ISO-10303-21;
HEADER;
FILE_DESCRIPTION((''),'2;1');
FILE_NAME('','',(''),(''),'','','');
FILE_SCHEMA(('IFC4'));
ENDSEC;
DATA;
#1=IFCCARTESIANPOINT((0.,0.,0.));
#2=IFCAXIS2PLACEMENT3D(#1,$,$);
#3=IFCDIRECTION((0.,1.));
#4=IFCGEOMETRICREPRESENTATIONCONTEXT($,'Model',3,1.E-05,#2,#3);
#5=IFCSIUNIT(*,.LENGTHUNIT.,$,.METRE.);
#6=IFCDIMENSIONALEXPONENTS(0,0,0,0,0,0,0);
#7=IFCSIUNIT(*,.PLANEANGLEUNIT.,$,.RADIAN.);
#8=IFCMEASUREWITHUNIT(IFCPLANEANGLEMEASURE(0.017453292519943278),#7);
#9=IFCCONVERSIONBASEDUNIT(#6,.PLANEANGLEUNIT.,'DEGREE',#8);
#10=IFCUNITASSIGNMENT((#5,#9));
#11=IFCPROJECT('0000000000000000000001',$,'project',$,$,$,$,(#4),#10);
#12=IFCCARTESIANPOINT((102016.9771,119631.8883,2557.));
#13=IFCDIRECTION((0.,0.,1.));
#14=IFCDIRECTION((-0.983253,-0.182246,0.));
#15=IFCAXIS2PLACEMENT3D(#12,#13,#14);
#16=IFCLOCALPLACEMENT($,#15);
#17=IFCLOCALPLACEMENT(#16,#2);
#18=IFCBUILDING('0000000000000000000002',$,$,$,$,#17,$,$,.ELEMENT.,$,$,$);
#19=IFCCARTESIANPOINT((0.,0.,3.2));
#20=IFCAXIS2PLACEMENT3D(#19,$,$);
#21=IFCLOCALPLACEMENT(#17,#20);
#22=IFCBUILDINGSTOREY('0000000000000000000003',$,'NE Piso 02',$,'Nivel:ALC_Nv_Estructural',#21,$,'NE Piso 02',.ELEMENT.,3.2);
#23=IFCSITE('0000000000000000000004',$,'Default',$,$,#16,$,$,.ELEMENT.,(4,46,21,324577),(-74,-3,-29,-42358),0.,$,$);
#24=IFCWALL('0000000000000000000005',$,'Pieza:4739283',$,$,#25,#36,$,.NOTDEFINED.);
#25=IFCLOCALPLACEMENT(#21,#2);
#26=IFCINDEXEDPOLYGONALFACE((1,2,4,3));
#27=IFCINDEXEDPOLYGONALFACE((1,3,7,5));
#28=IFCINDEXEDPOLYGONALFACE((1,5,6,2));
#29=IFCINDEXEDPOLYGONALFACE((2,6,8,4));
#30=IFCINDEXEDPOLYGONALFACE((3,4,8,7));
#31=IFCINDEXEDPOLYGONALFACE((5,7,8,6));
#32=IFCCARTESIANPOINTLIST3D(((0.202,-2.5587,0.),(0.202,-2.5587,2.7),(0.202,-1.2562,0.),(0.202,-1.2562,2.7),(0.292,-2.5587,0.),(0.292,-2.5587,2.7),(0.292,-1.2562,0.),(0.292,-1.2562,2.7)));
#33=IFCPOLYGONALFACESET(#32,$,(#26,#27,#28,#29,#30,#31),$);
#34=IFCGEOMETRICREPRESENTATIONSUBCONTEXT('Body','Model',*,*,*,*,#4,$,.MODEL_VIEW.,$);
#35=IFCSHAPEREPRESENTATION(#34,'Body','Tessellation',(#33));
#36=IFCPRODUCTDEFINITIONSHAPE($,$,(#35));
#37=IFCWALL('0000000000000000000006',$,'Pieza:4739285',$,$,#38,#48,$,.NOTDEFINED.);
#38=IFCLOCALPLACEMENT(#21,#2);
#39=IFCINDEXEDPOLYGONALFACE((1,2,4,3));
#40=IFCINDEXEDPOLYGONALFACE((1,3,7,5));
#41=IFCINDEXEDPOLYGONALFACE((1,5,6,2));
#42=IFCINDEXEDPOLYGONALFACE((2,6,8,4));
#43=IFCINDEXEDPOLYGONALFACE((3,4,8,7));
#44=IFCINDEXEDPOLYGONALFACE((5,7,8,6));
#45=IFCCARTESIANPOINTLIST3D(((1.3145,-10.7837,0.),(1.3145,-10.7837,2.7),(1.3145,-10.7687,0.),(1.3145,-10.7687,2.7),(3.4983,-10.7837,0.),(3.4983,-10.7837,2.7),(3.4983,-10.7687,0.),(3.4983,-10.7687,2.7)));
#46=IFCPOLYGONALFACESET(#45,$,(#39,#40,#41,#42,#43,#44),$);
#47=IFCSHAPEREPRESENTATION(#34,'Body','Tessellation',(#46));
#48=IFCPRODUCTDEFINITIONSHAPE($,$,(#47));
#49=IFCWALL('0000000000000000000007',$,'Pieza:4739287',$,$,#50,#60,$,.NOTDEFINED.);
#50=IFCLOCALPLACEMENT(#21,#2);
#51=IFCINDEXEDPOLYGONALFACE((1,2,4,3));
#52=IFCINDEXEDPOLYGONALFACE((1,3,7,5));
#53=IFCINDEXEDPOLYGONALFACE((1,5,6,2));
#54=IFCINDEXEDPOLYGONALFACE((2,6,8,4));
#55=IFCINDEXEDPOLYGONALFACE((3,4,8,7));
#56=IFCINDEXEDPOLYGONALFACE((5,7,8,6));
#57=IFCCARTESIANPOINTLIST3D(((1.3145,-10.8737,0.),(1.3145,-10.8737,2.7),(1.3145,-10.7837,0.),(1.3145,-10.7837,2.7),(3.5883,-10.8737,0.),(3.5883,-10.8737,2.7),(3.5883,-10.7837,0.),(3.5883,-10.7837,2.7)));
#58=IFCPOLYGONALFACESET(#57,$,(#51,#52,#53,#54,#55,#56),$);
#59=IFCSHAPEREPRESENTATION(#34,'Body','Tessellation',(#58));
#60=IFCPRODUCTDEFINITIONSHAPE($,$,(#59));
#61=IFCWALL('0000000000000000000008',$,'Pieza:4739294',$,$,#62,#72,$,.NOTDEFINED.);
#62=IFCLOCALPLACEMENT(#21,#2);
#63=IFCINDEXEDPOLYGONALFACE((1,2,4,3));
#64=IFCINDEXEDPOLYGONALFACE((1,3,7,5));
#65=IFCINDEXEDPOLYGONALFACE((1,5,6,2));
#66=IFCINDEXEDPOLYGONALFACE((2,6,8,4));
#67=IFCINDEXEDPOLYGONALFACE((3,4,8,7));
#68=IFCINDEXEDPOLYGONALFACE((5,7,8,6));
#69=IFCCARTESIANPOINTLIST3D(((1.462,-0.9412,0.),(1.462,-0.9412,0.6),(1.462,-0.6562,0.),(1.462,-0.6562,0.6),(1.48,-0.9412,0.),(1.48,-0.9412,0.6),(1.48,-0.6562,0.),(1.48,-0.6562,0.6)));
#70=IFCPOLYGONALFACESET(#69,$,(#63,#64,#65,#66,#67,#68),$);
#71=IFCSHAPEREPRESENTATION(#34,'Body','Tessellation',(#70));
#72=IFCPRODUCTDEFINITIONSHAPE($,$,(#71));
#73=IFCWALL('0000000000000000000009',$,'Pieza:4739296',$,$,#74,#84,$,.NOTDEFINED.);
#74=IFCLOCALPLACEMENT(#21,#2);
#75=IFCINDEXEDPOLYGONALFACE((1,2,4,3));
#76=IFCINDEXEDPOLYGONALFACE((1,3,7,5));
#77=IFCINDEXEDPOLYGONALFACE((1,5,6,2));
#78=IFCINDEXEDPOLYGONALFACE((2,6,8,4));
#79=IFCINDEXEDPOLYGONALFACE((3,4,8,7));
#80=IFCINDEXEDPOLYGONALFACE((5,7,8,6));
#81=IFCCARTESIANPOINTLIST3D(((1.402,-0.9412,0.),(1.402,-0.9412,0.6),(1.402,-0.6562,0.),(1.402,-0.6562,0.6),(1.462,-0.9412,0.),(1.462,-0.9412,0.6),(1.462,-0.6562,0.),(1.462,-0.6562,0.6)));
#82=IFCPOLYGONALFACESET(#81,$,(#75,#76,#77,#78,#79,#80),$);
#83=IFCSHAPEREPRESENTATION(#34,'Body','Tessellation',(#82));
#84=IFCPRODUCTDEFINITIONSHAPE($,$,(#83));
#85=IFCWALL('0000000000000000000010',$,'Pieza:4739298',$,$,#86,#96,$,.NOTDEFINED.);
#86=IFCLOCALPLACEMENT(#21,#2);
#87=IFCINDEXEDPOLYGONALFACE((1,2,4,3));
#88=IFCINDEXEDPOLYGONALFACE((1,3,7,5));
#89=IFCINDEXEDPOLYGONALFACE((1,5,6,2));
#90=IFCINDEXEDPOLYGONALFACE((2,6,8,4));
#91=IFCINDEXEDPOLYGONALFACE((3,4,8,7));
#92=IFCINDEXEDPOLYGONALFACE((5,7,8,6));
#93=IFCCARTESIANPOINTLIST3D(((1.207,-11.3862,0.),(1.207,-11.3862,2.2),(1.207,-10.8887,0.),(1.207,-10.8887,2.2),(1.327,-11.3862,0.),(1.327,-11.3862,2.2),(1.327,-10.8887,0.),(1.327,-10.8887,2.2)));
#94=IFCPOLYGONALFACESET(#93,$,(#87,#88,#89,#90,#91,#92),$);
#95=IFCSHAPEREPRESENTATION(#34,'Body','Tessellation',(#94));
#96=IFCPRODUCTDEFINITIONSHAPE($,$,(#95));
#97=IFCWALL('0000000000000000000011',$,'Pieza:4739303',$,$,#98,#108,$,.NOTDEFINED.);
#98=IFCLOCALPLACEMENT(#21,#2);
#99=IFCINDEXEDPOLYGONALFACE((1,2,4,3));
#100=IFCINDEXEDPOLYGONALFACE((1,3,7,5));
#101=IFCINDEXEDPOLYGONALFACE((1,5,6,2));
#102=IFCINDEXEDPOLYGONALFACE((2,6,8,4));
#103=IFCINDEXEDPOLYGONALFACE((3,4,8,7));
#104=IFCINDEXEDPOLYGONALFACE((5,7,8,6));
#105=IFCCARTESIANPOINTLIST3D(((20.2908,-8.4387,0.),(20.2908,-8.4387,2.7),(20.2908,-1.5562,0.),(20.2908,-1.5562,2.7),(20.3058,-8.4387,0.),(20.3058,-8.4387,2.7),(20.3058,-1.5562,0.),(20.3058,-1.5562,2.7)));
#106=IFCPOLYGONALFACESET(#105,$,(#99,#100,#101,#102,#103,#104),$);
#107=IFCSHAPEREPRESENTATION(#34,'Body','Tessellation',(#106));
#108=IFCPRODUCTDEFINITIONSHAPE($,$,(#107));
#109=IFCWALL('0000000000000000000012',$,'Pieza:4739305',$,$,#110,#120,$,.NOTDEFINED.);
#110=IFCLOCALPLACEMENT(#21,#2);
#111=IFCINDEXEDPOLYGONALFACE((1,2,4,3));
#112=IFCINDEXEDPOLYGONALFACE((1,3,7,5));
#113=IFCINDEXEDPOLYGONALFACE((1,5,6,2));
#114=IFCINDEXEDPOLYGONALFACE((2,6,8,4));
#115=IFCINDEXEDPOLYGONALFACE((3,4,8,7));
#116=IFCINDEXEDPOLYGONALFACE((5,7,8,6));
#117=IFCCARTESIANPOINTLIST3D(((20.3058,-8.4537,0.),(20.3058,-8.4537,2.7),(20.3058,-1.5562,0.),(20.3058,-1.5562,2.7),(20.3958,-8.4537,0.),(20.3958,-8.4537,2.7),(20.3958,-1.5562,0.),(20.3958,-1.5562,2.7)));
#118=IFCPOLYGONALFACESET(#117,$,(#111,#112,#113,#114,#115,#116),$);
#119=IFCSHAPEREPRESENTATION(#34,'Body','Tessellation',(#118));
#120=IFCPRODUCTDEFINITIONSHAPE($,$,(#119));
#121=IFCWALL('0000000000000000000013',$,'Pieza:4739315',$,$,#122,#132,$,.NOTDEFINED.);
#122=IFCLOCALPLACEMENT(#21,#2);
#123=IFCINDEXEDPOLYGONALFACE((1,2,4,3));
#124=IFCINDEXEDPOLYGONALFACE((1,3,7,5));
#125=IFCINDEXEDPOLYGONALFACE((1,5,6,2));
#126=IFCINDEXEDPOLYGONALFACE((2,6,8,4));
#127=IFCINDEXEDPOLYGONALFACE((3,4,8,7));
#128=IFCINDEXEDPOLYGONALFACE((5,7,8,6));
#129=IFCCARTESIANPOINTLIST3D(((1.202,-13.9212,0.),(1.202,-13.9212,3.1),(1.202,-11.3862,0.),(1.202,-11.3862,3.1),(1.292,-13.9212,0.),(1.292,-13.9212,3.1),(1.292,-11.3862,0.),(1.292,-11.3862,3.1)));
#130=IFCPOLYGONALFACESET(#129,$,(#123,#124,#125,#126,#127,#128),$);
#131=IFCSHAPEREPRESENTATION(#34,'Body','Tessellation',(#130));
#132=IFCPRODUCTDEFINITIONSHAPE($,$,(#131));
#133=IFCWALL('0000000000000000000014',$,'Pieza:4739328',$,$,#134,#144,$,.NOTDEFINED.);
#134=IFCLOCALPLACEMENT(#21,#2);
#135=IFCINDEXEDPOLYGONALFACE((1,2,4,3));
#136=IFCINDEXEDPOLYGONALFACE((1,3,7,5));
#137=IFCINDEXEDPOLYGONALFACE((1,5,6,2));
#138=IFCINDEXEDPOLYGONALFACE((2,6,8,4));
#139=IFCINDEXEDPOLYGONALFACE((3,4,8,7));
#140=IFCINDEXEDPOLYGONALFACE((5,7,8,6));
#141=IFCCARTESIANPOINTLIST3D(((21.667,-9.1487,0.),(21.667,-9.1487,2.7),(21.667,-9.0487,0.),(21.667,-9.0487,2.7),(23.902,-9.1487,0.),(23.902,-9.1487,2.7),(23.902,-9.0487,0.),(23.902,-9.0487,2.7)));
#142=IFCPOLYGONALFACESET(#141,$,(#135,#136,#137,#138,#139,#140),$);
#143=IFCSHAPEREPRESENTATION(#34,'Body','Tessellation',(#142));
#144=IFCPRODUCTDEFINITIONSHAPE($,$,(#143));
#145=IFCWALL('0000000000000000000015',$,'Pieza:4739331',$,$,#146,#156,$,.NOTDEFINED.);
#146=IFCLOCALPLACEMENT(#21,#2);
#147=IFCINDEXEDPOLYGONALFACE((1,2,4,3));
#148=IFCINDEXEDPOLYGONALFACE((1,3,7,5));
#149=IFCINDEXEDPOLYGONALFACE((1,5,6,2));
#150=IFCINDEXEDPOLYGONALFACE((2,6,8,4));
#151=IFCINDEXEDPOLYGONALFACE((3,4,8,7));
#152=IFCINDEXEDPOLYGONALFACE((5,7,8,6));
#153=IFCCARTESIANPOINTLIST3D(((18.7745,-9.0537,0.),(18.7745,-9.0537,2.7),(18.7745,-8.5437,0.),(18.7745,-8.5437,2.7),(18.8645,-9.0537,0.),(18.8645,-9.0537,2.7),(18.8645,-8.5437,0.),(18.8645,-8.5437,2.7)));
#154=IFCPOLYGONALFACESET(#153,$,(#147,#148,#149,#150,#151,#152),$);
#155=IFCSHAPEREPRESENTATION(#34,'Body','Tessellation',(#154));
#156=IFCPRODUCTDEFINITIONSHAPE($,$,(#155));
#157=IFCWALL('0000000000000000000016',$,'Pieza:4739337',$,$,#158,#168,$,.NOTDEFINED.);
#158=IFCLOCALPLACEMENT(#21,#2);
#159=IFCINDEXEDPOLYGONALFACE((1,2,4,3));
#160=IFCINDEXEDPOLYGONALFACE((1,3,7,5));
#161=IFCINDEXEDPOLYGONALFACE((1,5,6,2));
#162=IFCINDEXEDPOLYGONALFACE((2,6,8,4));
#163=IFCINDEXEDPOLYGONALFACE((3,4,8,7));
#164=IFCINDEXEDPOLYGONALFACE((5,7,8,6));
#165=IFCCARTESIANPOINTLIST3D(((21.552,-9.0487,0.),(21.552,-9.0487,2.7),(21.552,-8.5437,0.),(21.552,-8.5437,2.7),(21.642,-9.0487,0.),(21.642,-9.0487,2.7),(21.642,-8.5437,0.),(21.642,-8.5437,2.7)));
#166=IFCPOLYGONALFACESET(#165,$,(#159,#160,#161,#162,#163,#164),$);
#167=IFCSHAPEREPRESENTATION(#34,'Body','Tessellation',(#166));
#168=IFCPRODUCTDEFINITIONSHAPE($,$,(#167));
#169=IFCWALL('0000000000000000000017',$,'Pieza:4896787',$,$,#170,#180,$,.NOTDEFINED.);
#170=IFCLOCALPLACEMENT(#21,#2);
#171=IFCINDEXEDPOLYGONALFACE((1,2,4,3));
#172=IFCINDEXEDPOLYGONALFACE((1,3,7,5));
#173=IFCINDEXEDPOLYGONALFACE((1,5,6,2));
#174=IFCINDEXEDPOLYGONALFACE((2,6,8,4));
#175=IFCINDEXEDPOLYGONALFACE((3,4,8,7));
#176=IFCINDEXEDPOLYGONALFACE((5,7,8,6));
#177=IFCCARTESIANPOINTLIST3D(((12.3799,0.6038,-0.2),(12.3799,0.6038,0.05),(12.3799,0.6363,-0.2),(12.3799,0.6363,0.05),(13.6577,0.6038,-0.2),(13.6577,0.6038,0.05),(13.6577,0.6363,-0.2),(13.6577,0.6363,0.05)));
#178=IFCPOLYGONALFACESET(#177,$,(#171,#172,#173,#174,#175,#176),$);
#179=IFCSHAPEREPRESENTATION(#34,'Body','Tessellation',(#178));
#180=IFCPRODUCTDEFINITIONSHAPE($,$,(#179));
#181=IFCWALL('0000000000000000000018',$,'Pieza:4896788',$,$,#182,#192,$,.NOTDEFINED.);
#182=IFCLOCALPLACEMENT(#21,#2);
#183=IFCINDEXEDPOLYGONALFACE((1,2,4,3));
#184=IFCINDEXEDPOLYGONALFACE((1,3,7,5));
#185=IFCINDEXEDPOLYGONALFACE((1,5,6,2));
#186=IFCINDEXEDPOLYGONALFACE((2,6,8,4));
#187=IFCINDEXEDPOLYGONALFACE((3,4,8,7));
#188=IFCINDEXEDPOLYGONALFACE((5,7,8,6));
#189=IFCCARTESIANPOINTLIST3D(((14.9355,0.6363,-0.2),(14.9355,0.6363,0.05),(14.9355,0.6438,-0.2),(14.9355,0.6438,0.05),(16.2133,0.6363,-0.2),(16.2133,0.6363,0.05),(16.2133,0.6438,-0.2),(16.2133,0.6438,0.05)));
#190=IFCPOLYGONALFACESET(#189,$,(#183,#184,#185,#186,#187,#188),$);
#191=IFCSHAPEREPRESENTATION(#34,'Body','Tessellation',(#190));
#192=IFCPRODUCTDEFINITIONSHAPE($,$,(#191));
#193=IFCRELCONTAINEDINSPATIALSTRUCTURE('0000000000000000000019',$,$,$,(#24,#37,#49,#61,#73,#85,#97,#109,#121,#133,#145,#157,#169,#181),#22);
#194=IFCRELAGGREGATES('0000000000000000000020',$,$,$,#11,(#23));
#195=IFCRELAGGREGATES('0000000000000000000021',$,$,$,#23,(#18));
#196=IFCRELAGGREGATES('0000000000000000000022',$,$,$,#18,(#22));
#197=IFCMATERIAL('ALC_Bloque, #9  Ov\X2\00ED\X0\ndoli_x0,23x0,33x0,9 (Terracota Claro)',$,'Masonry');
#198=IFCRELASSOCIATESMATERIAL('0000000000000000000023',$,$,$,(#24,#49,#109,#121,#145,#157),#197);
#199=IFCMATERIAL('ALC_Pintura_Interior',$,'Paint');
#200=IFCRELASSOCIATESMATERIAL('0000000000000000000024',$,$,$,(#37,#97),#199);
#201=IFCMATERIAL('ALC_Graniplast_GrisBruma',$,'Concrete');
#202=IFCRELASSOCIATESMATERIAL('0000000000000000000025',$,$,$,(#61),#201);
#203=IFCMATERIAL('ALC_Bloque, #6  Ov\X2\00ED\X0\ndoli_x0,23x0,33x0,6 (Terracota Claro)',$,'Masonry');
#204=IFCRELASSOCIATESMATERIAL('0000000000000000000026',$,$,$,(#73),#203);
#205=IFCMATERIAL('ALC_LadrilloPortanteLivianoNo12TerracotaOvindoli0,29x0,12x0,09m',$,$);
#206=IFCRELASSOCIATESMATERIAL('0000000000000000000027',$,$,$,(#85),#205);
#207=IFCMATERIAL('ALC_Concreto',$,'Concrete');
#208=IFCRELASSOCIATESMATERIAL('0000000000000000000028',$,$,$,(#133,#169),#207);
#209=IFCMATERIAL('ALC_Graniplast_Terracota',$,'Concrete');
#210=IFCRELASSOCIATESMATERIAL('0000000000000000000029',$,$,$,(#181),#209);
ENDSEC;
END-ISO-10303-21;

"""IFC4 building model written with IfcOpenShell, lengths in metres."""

from ifc_helpers import new_model, entity, si_unit, converted_unit, direction, frame, frame_2d, origin, origin_2d_with_axis, place, context, subcontext, project, spatial, rectangle, extrude, material, element, save


model = new_model("IFC4")

# Units and contexts
model_context = context("Model", 3, precision=1e-05, world=origin(), true_north=direction((0.0, 1.0)))
body_context = subcontext(model_context, "Body", "Model", "MODEL_VIEW")
ifc_project = project(units=[si_unit("LENGTHUNIT", "METRE"), converted_unit("PLANEANGLEUNIT", "DEGREE", entity("IfcPlaneAngleMeasure", 0.017453292519943278), si_unit("PLANEANGLEUNIT", "RADIAN"), dimensions=[0, 0, 0, 0, 0, 0, 0])], contexts=[model_context])

# Site, building, storey
site_placement = place(None, frame((102016.9771, 119631.8883, 2557.0), z_axis=(0.0, 0.0, 1.0), x_axis=(-0.983253, -0.182246, 0.0)))
site = spatial("IfcSite", under=ifc_project, at=site_placement, Name="Default", CompositionType="ELEMENT", RefLatitude=(4, 46, 21, 324577), RefLongitude=(-74, -3, -29, -42358), RefElevation=0.0)
building_placement = place(site_placement, origin())
building = spatial("IfcBuilding", under=site, at=building_placement, CompositionType="ELEMENT")
storey_placement = place(building_placement, frame((0.0, 0.0, 3.2)))
storey = spatial("IfcBuildingStorey", under=building, at=storey_placement, Name="NE Piso 02", ObjectType="Nivel:ALC_Nv_Estructural", LongName="NE Piso 02", CompositionType="ELEMENT", Elevation=3.2)

# Walls
ifc_material_1 = material(Name="ALC_Bloque, #9  Ovíndoli_x0,23x0,33x0,9 (Terracota Claro)", Category="Masonry")
wall_1_placement = place(storey_placement, origin())
element("IfcWall", 1, at=wall_1_placement, inside=storey, material=ifc_material_1, Name="Pieza:4739283", PredefinedType="NOTDEFINED", context=body_context, shape_type="SweptSolid", body=[
    extrude(rectangle(XDim=1.3025, YDim=0.09, at=frame_2d((0.0, 0.0), x_axis=(1.0, 0.0))), frame((0.247, -1.9074, 0.0), z_axis=(0.0, 0.0, 1.0), x_axis=(0.0, -1.0, 0.0)), (0.0, 0.0, 1.0), 2.7),
])
ifc_material_2 = material(Name="ALC_Pintura_Interior", Category="Paint")
wall_2_placement = place(storey_placement, origin())
element("IfcWall", 2, at=wall_2_placement, inside=storey, material=ifc_material_2, Name="Pieza:4739285", PredefinedType="NOTDEFINED", context=body_context, shape_type="SweptSolid", body=[
    extrude(rectangle(XDim=0.015, YDim=2.1838, at=frame_2d((0.0, 0.0), x_axis=(1.0, 0.0))), frame((2.4064, -10.7762, 0.0), z_axis=(0.0, 0.0, 1.0), x_axis=(0.0, -1.0, 0.0)), (0.0, 0.0, 1.0), 2.7),
])
wall_3_placement = place(storey_placement, origin())
element("IfcWall", 3, at=wall_3_placement, inside=storey, material=ifc_material_1, Name="Pieza:4739287", PredefinedType="NOTDEFINED", context=body_context, shape_type="SweptSolid", body=[
    extrude(rectangle(XDim=0.09, YDim=2.2738, at=frame_2d((0.0, 0.0), x_axis=(1.0, 0.0))), frame((2.4514, -10.8287, 0.0), z_axis=(0.0, 0.0, 1.0), x_axis=(0.0, -1.0, 0.0)), (0.0, 0.0, 1.0), 2.7),
])
ifc_material_3 = material(Name="ALC_Graniplast_GrisBruma", Category="Concrete")
wall_4_placement = place(storey_placement, origin())
element("IfcWall", 4, at=wall_4_placement, inside=storey, material=ifc_material_3, Name="Pieza:4739294", PredefinedType="NOTDEFINED", context=body_context, shape_type="SweptSolid", body=[
    extrude(rectangle(XDim=0.285, YDim=0.018, at=frame_2d((0.0, 0.0), x_axis=(1.0, 0.0))), frame((1.471, -0.7987, 0.0), z_axis=(0.0, 0.0, 1.0), x_axis=(0.0, -1.0, 0.0)), (0.0, 0.0, 1.0), 0.6),
])
ifc_material_4 = material(Name="ALC_Bloque, #6  Ovíndoli_x0,23x0,33x0,6 (Terracota Claro)", Category="Masonry")
wall_5_placement = place(storey_placement, origin())
element("IfcWall", 5, at=wall_5_placement, inside=storey, material=ifc_material_4, Name="Pieza:4739296", PredefinedType="NOTDEFINED", context=body_context, shape_type="SweptSolid", body=[
    extrude(rectangle(XDim=0.285, YDim=0.06, at=frame_2d((0.0, 0.0), x_axis=(1.0, 0.0))), frame((1.432, -0.7987, 0.0), z_axis=(0.0, 0.0, 1.0), x_axis=(0.0, -1.0, 0.0)), (0.0, 0.0, 1.0), 0.6),
])
ifc_material_5 = material(Name="ALC_LadrilloPortanteLivianoNo12TerracotaOvindoli0,29x0,12x0,09m")
wall_6_placement = place(storey_placement, origin())
element("IfcWall", 6, at=wall_6_placement, inside=storey, material=ifc_material_5, Name="Pieza:4739298", PredefinedType="NOTDEFINED", context=body_context, shape_type="SweptSolid", body=[
    extrude(rectangle(XDim=0.4975, YDim=0.12, at=frame_2d((0.0, 0.0), x_axis=(1.0, 0.0))), frame((1.267, -11.1374, 0.0), z_axis=(0.0, 0.0, 1.0), x_axis=(0.0, -1.0, 0.0)), (0.0, 0.0, 1.0), 2.2),
])
wall_7_placement = place(storey_placement, origin())
element("IfcWall", 7, at=wall_7_placement, inside=storey, material=ifc_material_2, Name="Pieza:4739303", PredefinedType="NOTDEFINED", context=body_context, shape_type="SweptSolid", body=[
    extrude(rectangle(XDim=6.8825, YDim=0.015, at=frame_2d((0.0, 0.0), x_axis=(1.0, 0.0))), frame((20.2983, -4.9974, 0.0), z_axis=(0.0, 0.0, 1.0), x_axis=(0.0, -1.0, 0.0)), (0.0, 0.0, 1.0), 2.7),
])
wall_8_placement = place(storey_placement, origin())
element("IfcWall", 8, at=wall_8_placement, inside=storey, material=ifc_material_1, Name="Pieza:4739305", PredefinedType="NOTDEFINED", context=body_context, shape_type="SweptSolid", body=[
    extrude(rectangle(XDim=6.8975, YDim=0.09, at=frame_2d((0.0, 0.0), x_axis=(1.0, 0.0))), frame((20.3508, -5.0049, 0.0), z_axis=(0.0, 0.0, 1.0), x_axis=(0.0, -1.0, 0.0)), (0.0, 0.0, 1.0), 2.7),
])
wall_9_placement = place(storey_placement, origin())
element("IfcWall", 9, at=wall_9_placement, inside=storey, material=ifc_material_1, Name="Pieza:4739315", PredefinedType="NOTDEFINED", context=body_context, shape_type="SweptSolid", body=[
    extrude(rectangle(XDim=2.535, YDim=0.09, at=frame_2d((0.0, 0.0), x_axis=(1.0, 0.0))), frame((1.247, -12.6537, 0.0), z_axis=(0.0, 0.0, 1.0), x_axis=(0.0, -1.0, 0.0)), (0.0, 0.0, 1.0), 3.1),
])
ifc_material_6 = material(Name="ALC_Concreto", Category="Concrete")
wall_10_placement = place(storey_placement, origin())
element("IfcWall", 10, at=wall_10_placement, inside=storey, material=ifc_material_6, Name="Pieza:4739328", PredefinedType="NOTDEFINED", context=body_context, shape_type="SweptSolid", body=[
    extrude(rectangle(XDim=0.1, YDim=2.235, at=frame_2d((0.0, 0.0), x_axis=(1.0, 0.0))), frame((22.7845, -9.0987, 0.0), z_axis=(0.0, 0.0, 1.0), x_axis=(0.0, -1.0, 0.0)), (0.0, 0.0, 1.0), 2.7),
])
wall_11_placement = place(storey_placement, origin())
element("IfcWall", 11, at=wall_11_placement, inside=storey, material=ifc_material_1, Name="Pieza:4739331", PredefinedType="NOTDEFINED", context=body_context, shape_type="SweptSolid", body=[
    extrude(rectangle(XDim=0.51, YDim=0.09, at=origin_2d_with_axis()), frame((18.8195, -8.7987, 0.0), z_axis=(0.0, 0.0, 1.0), x_axis=(0.0, -1.0, 0.0)), (0.0, 0.0, 1.0), 2.7),
])
wall_12_placement = place(storey_placement, origin())
element("IfcWall", 12, at=wall_12_placement, inside=storey, material=ifc_material_1, Name="Pieza:4739337", PredefinedType="NOTDEFINED", context=body_context, shape_type="SweptSolid", body=[
    extrude(rectangle(XDim=0.505, YDim=0.09, at=origin_2d_with_axis()), frame((21.597, -8.7962, 0.0), z_axis=(0.0, 0.0, 1.0), x_axis=(0.0, -1.0, 0.0)), (0.0, 0.0, 1.0), 2.7),
])
wall_13_placement = place(storey_placement, frame((0.0, 0.0, -0.2)))
element("IfcWall", 13, at=wall_13_placement, inside=storey, material=ifc_material_6, Name="Pieza:4896787", PredefinedType="NOTDEFINED", context=body_context, shape_type="SweptSolid", body=[
    extrude(rectangle(XDim=0.0325, YDim=1.2778, at=frame_2d((0.0, 0.0), x_axis=(1.0, 0.0))), frame((13.0188, 0.6201, 0.0), z_axis=(0.0, 0.0, 1.0), x_axis=(0.0, -1.0, 0.0)), (0.0, 0.0, 1.0), 0.25),
])
ifc_material_7 = material(Name="ALC_Graniplast_Terracota", Category="Concrete")
wall_14_placement = place(storey_placement, frame((0.0, 0.0, -0.2)))
element("IfcWall", 14, at=wall_14_placement, inside=storey, material=ifc_material_7, Name="Pieza:4896788", PredefinedType="NOTDEFINED", context=body_context, shape_type="SweptSolid", body=[
    extrude(rectangle(XDim=0.0075, YDim=1.2778, at=origin_2d_with_axis()), frame((15.5744, 0.6401, 0.0), z_axis=(0.0, 0.0, 1.0), x_axis=(0.0, -1.0, 0.0)), (0.0, 0.0, 1.0), 0.25),
])

save(model, "model.ifc")
